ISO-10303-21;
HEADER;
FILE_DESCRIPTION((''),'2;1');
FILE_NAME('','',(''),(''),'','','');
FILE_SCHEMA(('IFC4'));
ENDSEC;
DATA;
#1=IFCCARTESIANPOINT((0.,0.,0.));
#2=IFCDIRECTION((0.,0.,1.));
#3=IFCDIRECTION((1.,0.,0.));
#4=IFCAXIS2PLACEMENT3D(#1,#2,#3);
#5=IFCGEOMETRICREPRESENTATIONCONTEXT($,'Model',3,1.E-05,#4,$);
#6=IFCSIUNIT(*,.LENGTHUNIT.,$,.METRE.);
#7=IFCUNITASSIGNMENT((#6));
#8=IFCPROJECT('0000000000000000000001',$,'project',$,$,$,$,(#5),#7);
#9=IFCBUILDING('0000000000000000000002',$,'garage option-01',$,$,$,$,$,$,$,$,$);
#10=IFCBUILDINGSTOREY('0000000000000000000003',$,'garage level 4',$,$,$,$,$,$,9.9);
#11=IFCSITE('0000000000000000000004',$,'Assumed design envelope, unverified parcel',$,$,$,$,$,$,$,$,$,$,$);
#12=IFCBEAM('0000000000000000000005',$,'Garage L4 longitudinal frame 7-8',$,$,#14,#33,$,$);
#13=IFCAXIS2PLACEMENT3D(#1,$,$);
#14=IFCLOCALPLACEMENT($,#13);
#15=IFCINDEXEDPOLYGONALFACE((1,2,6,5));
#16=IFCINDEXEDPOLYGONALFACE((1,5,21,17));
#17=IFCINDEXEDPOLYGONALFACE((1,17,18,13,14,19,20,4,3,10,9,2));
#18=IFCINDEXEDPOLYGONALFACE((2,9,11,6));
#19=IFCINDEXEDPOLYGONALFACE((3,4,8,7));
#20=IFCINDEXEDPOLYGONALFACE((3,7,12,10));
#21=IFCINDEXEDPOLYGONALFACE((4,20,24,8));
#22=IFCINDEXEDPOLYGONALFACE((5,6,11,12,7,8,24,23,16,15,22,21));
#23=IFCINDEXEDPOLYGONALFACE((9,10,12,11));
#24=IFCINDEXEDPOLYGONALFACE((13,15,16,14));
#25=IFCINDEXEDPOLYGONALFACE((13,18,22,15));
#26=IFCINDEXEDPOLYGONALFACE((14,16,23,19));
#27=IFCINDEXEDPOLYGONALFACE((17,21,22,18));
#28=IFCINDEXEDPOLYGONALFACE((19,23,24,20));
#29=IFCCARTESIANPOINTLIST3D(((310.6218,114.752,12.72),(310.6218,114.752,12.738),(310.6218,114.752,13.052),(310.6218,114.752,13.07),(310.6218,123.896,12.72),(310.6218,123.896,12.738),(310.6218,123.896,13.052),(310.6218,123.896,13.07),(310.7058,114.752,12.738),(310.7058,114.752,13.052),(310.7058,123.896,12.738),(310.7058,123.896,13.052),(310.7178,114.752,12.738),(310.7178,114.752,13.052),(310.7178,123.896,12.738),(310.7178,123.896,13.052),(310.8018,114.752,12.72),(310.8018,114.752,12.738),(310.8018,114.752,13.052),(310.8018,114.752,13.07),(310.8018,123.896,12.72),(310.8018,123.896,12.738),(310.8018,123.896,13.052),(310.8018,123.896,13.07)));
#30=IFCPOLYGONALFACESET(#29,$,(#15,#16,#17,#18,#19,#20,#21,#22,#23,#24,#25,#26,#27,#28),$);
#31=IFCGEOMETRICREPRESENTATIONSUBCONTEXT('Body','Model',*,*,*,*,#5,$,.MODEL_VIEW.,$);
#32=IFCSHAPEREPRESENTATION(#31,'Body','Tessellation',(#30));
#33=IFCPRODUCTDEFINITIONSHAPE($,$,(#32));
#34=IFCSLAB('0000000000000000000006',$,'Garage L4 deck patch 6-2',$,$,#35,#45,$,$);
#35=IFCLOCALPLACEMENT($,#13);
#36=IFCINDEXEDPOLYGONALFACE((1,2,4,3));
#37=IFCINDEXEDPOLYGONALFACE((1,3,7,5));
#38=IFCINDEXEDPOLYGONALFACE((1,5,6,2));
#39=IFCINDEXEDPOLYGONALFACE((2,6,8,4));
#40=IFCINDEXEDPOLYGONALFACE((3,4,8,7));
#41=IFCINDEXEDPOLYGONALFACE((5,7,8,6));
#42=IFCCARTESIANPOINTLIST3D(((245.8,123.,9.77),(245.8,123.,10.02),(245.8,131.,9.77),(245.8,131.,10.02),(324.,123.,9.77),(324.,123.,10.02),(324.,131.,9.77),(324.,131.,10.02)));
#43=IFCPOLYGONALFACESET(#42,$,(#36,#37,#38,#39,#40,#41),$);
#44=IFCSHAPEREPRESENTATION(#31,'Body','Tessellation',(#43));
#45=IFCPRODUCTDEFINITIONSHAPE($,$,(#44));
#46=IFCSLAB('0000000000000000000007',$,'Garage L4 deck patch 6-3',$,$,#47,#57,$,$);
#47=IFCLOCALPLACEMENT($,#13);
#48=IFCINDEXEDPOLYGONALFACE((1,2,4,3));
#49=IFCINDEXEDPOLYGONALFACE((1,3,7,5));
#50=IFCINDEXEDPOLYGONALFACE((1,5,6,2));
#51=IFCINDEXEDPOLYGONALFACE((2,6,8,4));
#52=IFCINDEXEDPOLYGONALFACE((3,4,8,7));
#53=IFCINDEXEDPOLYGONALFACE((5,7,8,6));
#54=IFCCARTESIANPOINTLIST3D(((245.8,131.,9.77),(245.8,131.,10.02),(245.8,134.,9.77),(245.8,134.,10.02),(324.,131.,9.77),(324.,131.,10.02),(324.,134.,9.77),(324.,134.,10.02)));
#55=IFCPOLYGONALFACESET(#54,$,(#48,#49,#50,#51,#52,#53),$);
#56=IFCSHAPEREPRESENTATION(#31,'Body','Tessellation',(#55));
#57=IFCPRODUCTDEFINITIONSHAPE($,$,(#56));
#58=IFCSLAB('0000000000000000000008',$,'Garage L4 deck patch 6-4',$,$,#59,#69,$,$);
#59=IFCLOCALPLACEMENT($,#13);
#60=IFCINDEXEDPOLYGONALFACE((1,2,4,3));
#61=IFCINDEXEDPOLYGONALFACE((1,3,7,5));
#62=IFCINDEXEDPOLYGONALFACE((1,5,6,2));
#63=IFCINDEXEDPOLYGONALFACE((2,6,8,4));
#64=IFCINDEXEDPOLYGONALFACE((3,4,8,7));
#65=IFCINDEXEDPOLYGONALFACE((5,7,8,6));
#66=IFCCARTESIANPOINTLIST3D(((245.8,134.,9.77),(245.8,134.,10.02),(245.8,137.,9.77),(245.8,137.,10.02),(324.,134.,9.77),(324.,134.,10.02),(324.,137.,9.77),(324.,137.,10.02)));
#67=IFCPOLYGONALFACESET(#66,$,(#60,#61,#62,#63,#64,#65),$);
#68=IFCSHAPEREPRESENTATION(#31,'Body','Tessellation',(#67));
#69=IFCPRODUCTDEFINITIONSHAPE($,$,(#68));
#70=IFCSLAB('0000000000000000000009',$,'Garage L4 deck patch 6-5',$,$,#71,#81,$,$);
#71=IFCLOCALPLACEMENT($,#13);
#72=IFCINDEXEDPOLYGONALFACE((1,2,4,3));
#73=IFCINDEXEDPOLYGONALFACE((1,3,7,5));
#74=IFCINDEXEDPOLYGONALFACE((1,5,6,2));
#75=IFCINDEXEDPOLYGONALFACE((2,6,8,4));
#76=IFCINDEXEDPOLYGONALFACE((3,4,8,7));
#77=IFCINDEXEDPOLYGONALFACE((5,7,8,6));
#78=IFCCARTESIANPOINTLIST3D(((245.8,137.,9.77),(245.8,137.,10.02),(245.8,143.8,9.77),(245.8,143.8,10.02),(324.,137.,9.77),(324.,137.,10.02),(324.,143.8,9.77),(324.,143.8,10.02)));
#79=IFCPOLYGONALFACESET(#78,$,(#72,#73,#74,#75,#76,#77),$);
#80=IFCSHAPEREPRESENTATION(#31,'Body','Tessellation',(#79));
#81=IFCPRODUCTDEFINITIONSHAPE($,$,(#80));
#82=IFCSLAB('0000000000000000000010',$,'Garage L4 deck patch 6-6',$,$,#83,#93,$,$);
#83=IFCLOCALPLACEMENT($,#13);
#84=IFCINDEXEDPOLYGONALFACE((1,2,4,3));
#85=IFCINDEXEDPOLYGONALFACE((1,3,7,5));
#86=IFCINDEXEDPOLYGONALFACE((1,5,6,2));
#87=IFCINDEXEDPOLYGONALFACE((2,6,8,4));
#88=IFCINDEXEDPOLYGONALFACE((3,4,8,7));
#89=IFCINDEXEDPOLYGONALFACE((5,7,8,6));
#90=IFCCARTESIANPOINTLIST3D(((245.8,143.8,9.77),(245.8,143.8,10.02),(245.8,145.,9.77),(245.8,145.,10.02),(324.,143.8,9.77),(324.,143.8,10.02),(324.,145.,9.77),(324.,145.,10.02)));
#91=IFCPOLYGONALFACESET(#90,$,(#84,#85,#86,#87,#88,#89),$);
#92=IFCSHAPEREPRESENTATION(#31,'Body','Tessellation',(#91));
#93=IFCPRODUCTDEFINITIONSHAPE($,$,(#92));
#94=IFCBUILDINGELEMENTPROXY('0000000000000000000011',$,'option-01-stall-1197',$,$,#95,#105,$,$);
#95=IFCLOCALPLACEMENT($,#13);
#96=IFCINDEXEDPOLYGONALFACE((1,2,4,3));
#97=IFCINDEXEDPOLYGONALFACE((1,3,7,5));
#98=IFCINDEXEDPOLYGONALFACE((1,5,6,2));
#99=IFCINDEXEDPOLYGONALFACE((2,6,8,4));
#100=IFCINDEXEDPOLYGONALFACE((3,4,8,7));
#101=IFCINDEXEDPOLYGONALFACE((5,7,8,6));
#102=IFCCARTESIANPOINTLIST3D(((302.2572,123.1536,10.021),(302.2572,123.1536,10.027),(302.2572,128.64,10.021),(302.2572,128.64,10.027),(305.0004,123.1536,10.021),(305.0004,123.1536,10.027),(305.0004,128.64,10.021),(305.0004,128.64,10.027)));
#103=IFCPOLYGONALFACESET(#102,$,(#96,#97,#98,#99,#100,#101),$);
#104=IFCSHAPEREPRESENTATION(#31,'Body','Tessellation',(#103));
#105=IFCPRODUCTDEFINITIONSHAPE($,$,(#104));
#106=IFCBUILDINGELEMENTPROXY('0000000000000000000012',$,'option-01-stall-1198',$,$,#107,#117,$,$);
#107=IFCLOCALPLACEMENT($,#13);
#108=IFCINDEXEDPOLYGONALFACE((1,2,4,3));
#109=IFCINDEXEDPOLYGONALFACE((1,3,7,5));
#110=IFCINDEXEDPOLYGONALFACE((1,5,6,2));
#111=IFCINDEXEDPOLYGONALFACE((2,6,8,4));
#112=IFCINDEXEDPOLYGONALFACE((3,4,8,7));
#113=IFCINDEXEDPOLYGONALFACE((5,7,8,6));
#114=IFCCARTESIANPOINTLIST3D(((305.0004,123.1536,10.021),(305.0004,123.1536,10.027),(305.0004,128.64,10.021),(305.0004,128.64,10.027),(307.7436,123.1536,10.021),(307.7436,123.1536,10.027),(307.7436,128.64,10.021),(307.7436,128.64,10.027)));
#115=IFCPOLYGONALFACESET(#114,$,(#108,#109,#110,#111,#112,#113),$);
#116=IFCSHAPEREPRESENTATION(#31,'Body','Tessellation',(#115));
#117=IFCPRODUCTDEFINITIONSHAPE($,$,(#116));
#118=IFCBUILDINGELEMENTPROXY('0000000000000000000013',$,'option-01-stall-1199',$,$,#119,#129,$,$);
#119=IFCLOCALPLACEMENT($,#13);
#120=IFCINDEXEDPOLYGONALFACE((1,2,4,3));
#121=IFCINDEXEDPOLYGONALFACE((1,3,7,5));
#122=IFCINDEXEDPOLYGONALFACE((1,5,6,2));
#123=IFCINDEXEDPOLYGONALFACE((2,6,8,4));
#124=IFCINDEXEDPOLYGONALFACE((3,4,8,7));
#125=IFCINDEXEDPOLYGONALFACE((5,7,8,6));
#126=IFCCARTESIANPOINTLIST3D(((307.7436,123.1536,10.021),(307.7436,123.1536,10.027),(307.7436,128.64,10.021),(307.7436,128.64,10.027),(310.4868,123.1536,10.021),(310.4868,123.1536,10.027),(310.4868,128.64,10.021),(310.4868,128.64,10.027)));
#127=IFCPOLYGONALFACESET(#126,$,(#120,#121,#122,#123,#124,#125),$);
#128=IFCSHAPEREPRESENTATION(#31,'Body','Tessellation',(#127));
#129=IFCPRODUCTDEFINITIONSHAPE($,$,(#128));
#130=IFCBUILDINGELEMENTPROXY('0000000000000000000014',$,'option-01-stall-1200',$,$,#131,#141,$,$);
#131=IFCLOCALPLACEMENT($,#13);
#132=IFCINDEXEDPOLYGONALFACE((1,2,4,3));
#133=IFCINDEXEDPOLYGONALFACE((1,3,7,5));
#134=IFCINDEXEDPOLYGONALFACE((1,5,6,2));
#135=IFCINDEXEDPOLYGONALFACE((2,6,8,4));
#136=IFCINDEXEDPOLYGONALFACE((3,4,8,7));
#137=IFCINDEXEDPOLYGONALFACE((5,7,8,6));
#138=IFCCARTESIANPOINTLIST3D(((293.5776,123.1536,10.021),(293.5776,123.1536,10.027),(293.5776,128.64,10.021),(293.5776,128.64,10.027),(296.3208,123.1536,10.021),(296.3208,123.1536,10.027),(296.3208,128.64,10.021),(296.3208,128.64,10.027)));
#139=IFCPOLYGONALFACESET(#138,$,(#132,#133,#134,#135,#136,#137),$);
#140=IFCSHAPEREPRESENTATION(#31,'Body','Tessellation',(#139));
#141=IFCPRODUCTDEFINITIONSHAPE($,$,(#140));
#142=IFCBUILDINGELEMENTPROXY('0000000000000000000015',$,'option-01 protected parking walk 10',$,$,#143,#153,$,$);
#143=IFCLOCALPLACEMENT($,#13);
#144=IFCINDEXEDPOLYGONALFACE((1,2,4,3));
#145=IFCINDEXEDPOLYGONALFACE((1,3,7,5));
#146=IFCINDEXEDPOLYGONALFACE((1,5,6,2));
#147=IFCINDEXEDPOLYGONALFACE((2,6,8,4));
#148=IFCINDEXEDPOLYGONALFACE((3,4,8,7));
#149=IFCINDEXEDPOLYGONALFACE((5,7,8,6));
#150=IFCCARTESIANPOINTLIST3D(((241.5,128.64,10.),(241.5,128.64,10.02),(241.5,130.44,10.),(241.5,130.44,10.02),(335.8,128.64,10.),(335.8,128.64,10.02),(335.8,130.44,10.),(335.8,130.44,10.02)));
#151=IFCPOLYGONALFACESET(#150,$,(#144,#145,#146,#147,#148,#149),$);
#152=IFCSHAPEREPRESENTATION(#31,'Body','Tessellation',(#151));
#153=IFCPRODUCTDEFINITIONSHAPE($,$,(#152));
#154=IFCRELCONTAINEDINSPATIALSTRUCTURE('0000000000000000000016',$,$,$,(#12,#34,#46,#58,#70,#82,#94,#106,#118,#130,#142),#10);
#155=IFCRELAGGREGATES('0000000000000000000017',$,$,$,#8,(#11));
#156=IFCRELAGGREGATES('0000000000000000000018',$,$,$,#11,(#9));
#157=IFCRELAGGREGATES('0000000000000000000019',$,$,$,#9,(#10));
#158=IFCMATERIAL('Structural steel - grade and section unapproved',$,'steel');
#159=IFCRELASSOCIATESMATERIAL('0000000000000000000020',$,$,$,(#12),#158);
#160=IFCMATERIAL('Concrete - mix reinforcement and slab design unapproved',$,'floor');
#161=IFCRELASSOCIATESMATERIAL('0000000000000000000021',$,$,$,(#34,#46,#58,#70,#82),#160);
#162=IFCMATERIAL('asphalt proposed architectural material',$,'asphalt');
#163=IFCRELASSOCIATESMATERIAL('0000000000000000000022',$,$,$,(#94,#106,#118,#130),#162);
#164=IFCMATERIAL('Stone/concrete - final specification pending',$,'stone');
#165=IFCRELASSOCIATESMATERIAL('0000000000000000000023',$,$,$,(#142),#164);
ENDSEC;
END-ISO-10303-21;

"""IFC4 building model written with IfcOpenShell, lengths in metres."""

from ifc_helpers import new_model, si_unit, frame, origin_with_axes, place, context, subcontext, project, spatial, rectangle, i_section, extrude, material, element, save


model = new_model("IFC4")

# Units and contexts
model_context = context("Model", 3, precision=1e-05, world=origin_with_axes())
body_context = subcontext(model_context, "Body", "Model", "MODEL_VIEW")
ifc_project = project(units=[si_unit("LENGTHUNIT", "METRE")], contexts=[model_context])

# Site, building, storey
site = spatial("IfcSite", under=ifc_project, Name="Assumed design envelope, unverified parcel")
building = spatial("IfcBuilding", under=site, Name="garage option-01")
storey = spatial("IfcBuildingStorey", under=building, Name="garage level 4", Elevation=9.9)

# Shared definitions
ifc_material_1 = material(Name="Concrete - mix reinforcement and slab design unapproved", Category="floor")

# Beam
ifc_material_2 = material(Name="Structural steel - grade and section unapproved", Category="steel")
for number, where, z_axis, x_axis, name in (
    (1, (310.7118, 114.752, 12.895), (0.0, 1.0, 0.0), (-1.0, 0.0, 0.0), "Garage L4 longitudinal frame 7-8"),
):
    element("IfcBeam", number, at=place(None, frame(where, z_axis=z_axis, x_axis=x_axis)), inside=storey, material=ifc_material_2, Name=name, context=body_context, shape_type="SweptSolid", body=[
        extrude(i_section(OverallWidth=0.18, OverallDepth=0.35, WebThickness=0.012, FlangeThickness=0.018, FilletRadius=0.0), origin_with_axes(), (0.0, 0.0, 1.0), 9.144),
    ])

# Slabs
slab_1_placement = place(None, frame((284.9, 127.0, 9.77), z_axis=(0.0, 0.0, 1.0), x_axis=(1.0, 0.0, 0.0)))
element("IfcSlab", 2, at=slab_1_placement, inside=storey, material=ifc_material_1, Name="Garage L4 deck patch 6-2", context=body_context, shape_type="SweptSolid", body=[
    extrude(rectangle(XDim=78.2, YDim=8.0), origin_with_axes(), (0.0, 0.0, 1.0), 0.25),
])
for number, where, z_axis, x_axis, name in (
    (3, (284.9, 132.5, 9.77), (0.0, 0.0, 1.0), (1.0, 0.0, 0.0), "Garage L4 deck patch 6-3"),
    (4, (284.9, 135.5, 9.77), (0.0, 0.0, 1.0), (1.0, 0.0, 0.0), "Garage L4 deck patch 6-4"),
):
    element("IfcSlab", number, at=place(None, frame(where, z_axis=z_axis, x_axis=x_axis)), inside=storey, material=ifc_material_1, Name=name, context=body_context, shape_type="SweptSolid", body=[
        extrude(rectangle(XDim=78.2, YDim=3.0), origin_with_axes(), (0.0, 0.0, 1.0), 0.25),
    ])
slab_2_placement = place(None, frame((284.9, 140.4, 9.77), z_axis=(0.0, 0.0, 1.0), x_axis=(1.0, 0.0, 0.0)))
element("IfcSlab", 5, at=slab_2_placement, inside=storey, material=ifc_material_1, Name="Garage L4 deck patch 6-5", context=body_context, shape_type="SweptSolid", body=[
    extrude(rectangle(XDim=78.2, YDim=6.8), origin_with_axes(), (0.0, 0.0, 1.0), 0.25),
])
slab_3_placement = place(None, frame((284.9, 144.4, 9.77), z_axis=(0.0, 0.0, 1.0), x_axis=(1.0, 0.0, 0.0)))
element("IfcSlab", 6, at=slab_3_placement, inside=storey, material=ifc_material_1, Name="Garage L4 deck patch 6-6", context=body_context, shape_type="SweptSolid", body=[
    extrude(rectangle(XDim=78.2, YDim=1.2), origin_with_axes(), (0.0, 0.0, 1.0), 0.25),
])

# Building element proxies
ifc_material_3 = material(Name="asphalt proposed architectural material", Category="asphalt")
for number, where, z_axis, x_axis, name in (
    (7, (303.6288, 125.8968, 10.021), (0.0, 0.0, 1.0), (1.0, 0.0, 0.0), "option-01-stall-1197"),
    (8, (306.372, 125.8968, 10.021), (0.0, 0.0, 1.0), (1.0, 0.0, 0.0), "option-01-stall-1198"),
    (9, (309.1152, 125.8968, 10.021), (0.0, 0.0, 1.0), (1.0, 0.0, 0.0), "option-01-stall-1199"),
    (10, (294.9492, 125.8968, 10.021), (0.0, 0.0, 1.0), (1.0, 0.0, 0.0), "option-01-stall-1200"),
):
    element("IfcBuildingElementProxy", number, at=place(None, frame(where, z_axis=z_axis, x_axis=x_axis)), inside=storey, material=ifc_material_3, Name=name, context=body_context, shape_type="SweptSolid", body=[
        extrude(rectangle(XDim=2.7432, YDim=5.4864), origin_with_axes(), (0.0, 0.0, 1.0), 0.006),
    ])
ifc_material_4 = material(Name="Stone/concrete - final specification pending", Category="stone")
proxy_placement = place(None, frame((288.65, 129.54, 10.0), z_axis=(0.0, 0.0, 1.0), x_axis=(1.0, 0.0, 0.0)))
element("IfcBuildingElementProxy", 11, at=proxy_placement, inside=storey, material=ifc_material_4, Name="option-01 protected parking walk 10", context=body_context, shape_type="SweptSolid", body=[
    extrude(rectangle(XDim=94.3, YDim=1.8), origin_with_axes(), (0.0, 0.0, 1.0), 0.02),
])

save(model, "model.ifc")
